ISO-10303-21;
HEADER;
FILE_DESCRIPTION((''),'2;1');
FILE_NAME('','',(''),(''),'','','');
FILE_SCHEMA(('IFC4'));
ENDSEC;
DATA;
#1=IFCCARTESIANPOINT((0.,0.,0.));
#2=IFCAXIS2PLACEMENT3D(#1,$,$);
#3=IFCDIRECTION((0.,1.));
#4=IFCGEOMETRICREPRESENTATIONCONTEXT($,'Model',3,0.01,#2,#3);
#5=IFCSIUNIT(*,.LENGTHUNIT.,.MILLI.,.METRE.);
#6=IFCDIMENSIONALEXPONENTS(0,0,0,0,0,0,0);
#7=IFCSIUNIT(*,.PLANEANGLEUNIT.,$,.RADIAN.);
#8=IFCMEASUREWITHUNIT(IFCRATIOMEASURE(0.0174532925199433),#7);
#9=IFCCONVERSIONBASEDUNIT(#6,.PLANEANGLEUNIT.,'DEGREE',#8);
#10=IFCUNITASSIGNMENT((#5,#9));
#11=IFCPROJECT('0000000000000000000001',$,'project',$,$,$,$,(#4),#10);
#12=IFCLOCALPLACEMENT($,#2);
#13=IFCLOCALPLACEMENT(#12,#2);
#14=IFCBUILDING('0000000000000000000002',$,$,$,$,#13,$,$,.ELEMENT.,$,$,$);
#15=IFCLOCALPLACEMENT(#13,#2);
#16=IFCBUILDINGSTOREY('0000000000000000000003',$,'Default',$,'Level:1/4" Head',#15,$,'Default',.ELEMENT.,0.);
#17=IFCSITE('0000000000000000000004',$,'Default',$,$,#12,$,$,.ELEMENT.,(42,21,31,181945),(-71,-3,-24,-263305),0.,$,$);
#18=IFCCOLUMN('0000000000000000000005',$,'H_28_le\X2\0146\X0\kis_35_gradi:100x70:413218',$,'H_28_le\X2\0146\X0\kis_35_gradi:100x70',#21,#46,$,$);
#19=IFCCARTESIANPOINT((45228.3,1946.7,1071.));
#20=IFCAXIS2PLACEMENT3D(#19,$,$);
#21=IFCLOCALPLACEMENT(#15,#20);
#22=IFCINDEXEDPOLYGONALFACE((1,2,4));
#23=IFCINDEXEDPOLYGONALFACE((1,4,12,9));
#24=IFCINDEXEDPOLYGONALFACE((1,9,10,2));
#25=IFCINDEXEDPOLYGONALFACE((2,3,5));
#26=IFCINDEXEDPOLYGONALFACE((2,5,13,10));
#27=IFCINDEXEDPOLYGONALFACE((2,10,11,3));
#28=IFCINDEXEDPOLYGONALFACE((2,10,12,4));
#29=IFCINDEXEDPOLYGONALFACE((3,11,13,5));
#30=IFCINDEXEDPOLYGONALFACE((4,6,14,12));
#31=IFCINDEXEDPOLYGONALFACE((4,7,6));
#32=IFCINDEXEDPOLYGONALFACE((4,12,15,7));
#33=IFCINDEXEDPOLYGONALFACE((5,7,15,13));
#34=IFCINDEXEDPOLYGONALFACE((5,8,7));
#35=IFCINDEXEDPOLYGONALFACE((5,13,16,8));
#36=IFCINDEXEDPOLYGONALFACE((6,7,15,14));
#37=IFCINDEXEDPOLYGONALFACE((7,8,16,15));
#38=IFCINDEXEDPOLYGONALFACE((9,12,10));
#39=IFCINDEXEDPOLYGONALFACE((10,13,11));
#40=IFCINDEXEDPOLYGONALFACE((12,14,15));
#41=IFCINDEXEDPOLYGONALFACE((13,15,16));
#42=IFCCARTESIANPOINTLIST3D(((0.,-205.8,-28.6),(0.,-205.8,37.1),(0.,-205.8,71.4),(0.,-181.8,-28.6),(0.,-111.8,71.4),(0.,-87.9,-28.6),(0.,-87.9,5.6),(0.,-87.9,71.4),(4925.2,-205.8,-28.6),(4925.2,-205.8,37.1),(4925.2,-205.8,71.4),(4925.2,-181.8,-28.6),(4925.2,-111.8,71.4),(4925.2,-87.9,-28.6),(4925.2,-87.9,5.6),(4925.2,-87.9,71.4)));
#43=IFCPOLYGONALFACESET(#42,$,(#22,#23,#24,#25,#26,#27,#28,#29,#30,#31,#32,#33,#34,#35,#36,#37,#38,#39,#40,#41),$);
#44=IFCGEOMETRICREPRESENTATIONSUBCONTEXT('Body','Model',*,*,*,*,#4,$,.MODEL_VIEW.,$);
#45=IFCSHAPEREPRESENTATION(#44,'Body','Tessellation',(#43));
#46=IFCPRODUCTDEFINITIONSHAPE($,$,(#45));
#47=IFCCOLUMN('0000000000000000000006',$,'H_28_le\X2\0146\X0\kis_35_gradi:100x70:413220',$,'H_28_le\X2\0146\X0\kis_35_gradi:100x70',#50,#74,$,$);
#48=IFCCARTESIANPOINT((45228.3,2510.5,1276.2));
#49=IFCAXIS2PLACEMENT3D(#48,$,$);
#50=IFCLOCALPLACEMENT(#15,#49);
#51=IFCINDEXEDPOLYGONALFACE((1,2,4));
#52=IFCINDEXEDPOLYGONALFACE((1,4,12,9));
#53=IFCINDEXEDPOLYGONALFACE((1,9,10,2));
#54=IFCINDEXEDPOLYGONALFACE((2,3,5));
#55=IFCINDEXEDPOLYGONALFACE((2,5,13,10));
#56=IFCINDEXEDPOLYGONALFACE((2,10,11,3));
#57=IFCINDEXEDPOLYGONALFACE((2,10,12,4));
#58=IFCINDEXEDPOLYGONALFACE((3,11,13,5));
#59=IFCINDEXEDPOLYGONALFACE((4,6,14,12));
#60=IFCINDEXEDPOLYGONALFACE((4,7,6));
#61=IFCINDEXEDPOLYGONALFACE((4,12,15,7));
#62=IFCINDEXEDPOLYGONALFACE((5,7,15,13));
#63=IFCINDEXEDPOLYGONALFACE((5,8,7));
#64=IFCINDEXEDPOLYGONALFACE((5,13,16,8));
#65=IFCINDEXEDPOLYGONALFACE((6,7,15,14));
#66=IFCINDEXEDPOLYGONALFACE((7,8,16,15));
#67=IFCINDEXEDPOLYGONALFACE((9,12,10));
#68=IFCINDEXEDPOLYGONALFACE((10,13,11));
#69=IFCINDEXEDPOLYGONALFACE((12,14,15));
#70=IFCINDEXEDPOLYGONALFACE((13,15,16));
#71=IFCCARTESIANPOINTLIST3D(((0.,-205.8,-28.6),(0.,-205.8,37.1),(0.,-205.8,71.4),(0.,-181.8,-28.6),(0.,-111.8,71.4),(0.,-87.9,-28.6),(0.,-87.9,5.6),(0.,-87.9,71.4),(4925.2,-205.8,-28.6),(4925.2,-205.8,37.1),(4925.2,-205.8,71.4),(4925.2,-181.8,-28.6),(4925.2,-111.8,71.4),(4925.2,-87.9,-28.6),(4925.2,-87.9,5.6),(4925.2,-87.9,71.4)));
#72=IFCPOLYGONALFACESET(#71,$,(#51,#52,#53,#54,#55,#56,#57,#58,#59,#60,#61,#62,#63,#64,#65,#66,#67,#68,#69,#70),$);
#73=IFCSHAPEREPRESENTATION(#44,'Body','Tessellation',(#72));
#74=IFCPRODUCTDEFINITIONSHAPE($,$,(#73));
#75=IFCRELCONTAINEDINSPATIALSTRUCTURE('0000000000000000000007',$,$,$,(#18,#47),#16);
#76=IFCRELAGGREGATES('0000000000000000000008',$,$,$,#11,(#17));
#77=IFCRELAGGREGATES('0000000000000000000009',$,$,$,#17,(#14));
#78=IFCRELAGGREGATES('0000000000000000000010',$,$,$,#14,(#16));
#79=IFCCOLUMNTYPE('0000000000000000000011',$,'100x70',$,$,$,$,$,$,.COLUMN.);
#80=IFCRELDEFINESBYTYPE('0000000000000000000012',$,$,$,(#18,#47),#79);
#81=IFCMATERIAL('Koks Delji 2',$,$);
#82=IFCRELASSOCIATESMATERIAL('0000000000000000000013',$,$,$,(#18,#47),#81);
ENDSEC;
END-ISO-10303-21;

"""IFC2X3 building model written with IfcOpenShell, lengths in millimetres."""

from ifc_helpers import new_model, entity, si_unit, converted_unit, direction, frame, frame_2d, origin, place, context, subcontext, project, spatial, rectangle, extrude, boolean, source, transform, mapped, material, type_object, type_shapes, element, save


model = new_model("IFC2X3")

# Units and contexts
model_context = context("Model", 3, precision=0.01, world=origin(), true_north=direction((0.0, 1.0)))
body_context = subcontext(model_context, "Body", "Model", "MODEL_VIEW")
ifc_project = project(units=[si_unit("LENGTHUNIT", "METRE", prefix="MILLI"), converted_unit("PLANEANGLEUNIT", "DEGREE", entity("IfcRatioMeasure", 0.0174532925199433), si_unit("PLANEANGLEUNIT", "RADIAN"), dimensions=[0, 0, 0, 0, 0, 0, 0])], contexts=[model_context])

# Site, building, storey
site_placement = place(None, origin())
site = spatial("IfcSite", under=ifc_project, at=site_placement, Name="Default", CompositionType="ELEMENT", RefLatitude=(42, 21, 31, 181945), RefLongitude=(-71, -3, -24, -263305), RefElevation=0.0)
building_placement = place(site_placement, origin())
building = spatial("IfcBuilding", under=site, at=building_placement, CompositionType="ELEMENT")
storey_placement = place(building_placement, origin())
storey = spatial("IfcBuildingStorey", under=building, at=storey_placement, Name="Default", ObjectType="Level:1/4\" Head", LongName="Default", CompositionType="ELEMENT", Elevation=0.0)

# Columns
ifc_material_1 = material(Name="Koks Delji 2")
column_type = type_object("IfcColumnType", Name="100x70", PredefinedType="COLUMN")
shared_shape_1 = source(origin(), body_context, "Body", "CSG", [
    boolean("DIFFERENCE", extrude(rectangle(XDim=4925.2, YDim=117.9, at=frame_2d((0.0, 0.0), x_axis=(1.0, 0.0))), frame((2462.6, -146.8, -28.6)), (0.0, 0.0, 1.0), 100.0), extrude(rectangle(XDim=70.0, YDim=100.0, at=frame_2d((0.0, 0.0), x_axis=(0.0, 1.0))), frame((0.0, -146.8, 21.4), z_axis=(-1.0, 0.0, 0.0), x_axis=(0.0, -0.939693, -0.34202)), (0.0, 0.0, -1.0), 4925.2)),
])
type_shapes(column_type, [shared_shape_1])
for number, where, name in (
    (1, (45228.3, 1946.7, 1071.0), "H_28_leņkis_35_gradi:100x70:413218"),
    (2, (45228.3, 2510.5, 1276.2), "H_28_leņkis_35_gradi:100x70:413220"),
):
    element("IfcColumn", number, at=place(storey_placement, frame(where)), inside=storey, type_object=column_type, material=ifc_material_1, Name=name, ObjectType="H_28_leņkis_35_gradi:100x70", context=body_context, shape_type="MappedRepresentation", body=[
        mapped(shared_shape_1, transform((0.0, 0.0, 0.0), scale=1.0)),
    ])

save(model, "model.ifc")
